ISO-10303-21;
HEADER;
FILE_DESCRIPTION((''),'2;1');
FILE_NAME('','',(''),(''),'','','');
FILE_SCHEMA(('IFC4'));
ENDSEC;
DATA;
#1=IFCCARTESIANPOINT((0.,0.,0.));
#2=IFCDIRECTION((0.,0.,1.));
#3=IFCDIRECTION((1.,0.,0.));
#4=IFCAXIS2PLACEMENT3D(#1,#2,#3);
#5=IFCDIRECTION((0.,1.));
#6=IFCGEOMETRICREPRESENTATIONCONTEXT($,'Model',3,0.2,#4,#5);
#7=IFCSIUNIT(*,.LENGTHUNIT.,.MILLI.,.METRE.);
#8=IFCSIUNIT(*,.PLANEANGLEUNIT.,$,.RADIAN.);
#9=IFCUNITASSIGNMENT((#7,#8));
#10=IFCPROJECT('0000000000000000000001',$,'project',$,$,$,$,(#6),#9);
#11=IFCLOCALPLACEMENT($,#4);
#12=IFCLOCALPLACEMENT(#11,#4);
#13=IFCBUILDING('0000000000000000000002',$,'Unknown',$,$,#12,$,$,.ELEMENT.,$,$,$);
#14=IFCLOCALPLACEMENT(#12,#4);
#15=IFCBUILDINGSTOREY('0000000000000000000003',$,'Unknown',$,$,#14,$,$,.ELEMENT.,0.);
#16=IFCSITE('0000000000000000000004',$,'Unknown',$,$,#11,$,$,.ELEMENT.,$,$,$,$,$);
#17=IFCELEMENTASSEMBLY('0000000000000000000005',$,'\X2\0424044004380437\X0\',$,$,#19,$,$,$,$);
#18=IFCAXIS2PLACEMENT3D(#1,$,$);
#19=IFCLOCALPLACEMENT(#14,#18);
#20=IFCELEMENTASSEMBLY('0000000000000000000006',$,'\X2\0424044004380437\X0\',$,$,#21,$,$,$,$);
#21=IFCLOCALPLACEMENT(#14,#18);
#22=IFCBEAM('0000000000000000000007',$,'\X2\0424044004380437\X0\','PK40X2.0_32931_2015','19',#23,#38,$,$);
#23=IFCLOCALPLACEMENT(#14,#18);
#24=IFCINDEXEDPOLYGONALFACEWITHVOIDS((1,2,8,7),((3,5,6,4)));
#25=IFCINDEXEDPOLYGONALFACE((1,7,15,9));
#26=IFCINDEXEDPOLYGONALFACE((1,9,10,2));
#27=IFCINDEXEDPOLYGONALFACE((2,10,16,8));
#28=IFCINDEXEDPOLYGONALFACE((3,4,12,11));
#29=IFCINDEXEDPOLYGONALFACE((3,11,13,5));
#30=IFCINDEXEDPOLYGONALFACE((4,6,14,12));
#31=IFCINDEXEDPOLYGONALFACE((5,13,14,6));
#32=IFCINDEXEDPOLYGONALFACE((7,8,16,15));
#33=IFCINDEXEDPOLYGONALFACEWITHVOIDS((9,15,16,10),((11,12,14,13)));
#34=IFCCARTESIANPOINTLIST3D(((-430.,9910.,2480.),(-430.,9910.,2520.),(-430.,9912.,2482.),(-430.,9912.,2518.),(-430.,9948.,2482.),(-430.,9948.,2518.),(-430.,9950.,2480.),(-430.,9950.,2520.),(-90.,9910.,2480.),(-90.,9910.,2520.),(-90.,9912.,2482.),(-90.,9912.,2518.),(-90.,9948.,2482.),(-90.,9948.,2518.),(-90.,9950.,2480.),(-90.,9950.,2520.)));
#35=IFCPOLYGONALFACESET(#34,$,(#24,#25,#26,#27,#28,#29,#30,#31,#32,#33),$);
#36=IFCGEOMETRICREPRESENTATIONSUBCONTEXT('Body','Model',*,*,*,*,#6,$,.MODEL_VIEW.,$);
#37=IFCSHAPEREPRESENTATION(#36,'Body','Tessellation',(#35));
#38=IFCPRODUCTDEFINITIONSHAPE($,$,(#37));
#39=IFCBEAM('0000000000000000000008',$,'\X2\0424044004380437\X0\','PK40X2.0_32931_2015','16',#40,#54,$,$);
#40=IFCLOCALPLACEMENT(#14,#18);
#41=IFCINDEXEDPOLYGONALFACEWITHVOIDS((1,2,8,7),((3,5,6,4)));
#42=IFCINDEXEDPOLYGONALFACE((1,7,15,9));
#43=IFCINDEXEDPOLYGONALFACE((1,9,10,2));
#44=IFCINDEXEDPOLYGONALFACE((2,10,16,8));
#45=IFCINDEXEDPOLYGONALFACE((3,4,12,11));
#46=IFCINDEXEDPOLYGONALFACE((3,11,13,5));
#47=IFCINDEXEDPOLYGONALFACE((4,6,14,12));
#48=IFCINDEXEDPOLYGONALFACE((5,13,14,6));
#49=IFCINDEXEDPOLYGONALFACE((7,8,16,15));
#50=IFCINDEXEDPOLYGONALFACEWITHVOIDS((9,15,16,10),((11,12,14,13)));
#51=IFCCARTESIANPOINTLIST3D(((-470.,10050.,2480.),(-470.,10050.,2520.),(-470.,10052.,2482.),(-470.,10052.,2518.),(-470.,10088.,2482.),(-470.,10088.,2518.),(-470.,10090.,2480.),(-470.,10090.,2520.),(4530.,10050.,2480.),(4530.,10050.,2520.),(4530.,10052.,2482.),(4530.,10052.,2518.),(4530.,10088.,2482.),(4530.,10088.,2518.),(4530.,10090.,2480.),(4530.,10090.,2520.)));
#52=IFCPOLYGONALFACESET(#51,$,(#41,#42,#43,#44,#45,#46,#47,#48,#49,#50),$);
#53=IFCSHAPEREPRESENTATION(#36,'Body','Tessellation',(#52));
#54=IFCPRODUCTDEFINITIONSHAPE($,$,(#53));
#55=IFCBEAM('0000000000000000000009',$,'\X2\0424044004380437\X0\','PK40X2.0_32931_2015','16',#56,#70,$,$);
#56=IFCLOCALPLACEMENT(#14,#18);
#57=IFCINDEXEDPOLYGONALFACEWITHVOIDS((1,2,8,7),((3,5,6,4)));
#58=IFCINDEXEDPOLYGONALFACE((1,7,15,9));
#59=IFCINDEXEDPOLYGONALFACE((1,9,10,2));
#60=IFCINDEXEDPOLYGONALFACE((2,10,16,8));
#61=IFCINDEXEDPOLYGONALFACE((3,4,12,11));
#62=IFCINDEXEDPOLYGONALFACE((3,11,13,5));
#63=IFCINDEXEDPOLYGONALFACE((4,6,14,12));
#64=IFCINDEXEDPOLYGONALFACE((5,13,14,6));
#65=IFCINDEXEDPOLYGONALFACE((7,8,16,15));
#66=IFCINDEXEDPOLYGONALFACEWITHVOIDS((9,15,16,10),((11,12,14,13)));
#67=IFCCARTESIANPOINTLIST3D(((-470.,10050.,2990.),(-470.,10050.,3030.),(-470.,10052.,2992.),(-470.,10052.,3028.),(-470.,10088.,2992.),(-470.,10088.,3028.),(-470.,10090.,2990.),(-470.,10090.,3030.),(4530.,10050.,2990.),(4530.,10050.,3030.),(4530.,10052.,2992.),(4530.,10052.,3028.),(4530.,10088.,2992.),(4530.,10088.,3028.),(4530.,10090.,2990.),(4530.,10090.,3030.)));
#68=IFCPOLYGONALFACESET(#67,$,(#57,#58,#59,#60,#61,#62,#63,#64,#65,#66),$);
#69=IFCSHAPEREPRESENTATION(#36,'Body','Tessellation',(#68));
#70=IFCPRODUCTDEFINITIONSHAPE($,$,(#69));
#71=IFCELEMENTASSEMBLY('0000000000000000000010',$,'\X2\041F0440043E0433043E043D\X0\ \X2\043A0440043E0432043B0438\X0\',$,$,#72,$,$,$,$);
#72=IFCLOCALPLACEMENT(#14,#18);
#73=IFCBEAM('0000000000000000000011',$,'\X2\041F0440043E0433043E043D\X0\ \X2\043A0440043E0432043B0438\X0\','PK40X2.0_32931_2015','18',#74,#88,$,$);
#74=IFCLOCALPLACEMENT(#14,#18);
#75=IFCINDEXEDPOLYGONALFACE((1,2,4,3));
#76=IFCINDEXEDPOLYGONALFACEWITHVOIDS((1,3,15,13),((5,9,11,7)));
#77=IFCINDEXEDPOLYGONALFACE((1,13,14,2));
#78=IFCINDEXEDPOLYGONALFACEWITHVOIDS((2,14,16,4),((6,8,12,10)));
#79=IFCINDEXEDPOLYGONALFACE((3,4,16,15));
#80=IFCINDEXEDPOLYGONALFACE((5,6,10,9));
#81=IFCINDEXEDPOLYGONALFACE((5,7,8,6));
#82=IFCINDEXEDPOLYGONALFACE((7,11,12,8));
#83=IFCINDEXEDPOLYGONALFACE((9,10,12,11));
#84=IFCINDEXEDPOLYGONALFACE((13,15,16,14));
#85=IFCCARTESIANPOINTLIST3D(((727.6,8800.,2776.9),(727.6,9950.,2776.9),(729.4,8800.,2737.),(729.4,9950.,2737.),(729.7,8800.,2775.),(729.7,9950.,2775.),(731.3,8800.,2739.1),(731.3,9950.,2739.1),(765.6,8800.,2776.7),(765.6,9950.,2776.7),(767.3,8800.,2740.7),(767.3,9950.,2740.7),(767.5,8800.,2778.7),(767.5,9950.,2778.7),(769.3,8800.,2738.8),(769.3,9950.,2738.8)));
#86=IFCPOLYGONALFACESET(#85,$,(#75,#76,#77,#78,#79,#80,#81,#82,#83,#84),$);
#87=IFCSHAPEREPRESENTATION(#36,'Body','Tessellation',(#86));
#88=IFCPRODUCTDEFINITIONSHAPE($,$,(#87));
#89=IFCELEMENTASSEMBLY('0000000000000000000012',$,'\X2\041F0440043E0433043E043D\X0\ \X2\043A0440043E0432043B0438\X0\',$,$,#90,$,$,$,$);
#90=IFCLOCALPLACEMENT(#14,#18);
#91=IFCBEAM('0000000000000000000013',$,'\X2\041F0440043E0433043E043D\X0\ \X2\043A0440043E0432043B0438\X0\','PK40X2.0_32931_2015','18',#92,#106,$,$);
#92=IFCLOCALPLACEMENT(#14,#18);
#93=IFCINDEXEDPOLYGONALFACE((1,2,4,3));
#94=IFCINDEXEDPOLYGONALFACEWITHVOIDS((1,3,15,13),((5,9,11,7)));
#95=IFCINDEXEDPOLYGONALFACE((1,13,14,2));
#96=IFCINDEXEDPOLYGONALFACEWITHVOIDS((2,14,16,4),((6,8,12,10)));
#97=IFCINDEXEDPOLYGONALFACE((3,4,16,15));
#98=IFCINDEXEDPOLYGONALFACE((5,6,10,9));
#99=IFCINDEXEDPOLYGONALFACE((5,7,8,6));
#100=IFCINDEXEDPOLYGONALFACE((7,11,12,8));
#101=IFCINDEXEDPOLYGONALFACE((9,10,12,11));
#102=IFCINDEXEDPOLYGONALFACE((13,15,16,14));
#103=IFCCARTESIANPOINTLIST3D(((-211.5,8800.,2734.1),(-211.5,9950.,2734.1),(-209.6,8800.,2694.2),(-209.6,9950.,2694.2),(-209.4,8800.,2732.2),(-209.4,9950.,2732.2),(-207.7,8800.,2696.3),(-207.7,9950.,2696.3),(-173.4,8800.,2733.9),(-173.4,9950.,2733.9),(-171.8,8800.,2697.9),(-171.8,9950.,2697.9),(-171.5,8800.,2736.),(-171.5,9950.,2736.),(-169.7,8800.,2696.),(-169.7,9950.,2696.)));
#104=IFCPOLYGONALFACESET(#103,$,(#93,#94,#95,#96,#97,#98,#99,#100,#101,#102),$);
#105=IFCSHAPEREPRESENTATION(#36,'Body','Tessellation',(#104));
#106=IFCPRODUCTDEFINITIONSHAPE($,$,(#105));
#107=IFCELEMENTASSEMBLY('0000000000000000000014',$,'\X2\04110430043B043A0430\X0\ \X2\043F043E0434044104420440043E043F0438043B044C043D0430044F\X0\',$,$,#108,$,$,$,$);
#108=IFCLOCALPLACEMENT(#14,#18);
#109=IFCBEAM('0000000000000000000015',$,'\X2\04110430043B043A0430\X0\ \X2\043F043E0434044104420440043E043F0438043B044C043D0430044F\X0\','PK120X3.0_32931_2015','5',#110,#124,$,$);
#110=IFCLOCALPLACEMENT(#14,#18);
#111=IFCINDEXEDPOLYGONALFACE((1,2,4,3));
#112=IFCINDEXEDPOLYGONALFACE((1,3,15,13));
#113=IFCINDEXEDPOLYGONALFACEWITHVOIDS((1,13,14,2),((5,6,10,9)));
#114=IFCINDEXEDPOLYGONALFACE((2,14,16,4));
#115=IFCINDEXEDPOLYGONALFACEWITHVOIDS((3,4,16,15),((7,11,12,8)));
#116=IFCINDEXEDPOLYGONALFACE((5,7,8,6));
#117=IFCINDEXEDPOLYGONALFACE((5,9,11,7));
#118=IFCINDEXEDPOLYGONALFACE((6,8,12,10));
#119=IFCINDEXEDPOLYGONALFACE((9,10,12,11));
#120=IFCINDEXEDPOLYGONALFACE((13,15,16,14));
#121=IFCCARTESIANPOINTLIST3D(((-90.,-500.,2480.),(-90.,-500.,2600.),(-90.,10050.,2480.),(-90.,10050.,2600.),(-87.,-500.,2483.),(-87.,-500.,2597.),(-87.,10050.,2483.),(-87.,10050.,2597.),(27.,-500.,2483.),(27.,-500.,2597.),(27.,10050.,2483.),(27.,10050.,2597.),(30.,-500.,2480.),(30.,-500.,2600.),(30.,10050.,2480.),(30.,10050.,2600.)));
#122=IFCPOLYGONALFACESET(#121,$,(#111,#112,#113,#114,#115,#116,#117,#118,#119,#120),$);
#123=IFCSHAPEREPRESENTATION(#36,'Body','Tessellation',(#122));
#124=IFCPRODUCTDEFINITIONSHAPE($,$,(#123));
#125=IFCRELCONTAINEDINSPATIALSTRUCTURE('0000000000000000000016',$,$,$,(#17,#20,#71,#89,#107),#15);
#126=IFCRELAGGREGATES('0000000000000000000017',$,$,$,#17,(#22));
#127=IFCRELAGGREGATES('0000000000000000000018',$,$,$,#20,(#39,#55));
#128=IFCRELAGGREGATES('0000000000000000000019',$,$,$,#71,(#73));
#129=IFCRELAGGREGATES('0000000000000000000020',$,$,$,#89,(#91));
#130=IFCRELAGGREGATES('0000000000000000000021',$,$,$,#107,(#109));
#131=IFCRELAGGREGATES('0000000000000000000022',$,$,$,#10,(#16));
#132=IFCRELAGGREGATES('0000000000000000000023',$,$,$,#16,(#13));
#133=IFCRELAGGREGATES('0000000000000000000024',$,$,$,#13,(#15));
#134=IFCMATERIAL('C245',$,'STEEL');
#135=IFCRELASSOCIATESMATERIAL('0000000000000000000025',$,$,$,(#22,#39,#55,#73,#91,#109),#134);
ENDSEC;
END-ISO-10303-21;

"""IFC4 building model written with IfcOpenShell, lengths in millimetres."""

from ifc_helpers import new_model, si_unit, direction, frame, origin_with_axes, place, context, subcontext, project, spatial, line, indexed_curve, outline, extrude, material, element, aggregate, save


model = new_model("IFC4")

# Units and contexts
model_context = context("Model", 3, precision=0.2, world=origin_with_axes(), true_north=direction((0.0, 1.0)))
body_context = subcontext(model_context, "Body", "Model", "MODEL_VIEW")
ifc_project = project(units=[si_unit("LENGTHUNIT", "METRE", prefix="MILLI"), si_unit("PLANEANGLEUNIT", "RADIAN")], contexts=[model_context])

# Site, building, storey
site_placement = place(None, origin_with_axes())
site = spatial("IfcSite", under=ifc_project, at=site_placement, Name="Unknown", CompositionType="ELEMENT")
building_placement = place(site_placement, origin_with_axes())
building = spatial("IfcBuilding", under=site, at=building_placement, Name="Unknown", CompositionType="ELEMENT")
storey_placement = place(building_placement, origin_with_axes())
storey = spatial("IfcBuildingStorey", under=building, at=storey_placement, Name="Unknown", CompositionType="ELEMENT", Elevation=0.0)

# Element assemblies
assembly_1_placement = place(storey_placement, frame((-450.0, -500.0, 3010.0), z_axis=(1.0, 0.0, 0.0), x_axis=(0.0, 1.0, 0.0)))
assembly_1 = element("IfcElementAssembly", 1, at=assembly_1_placement, inside=storey, Name="Фриз")
ifc_material = material(Name="C245", Category="STEEL")
assembly_2_placement = place(storey_placement, frame((-470.0, 10070.0, 3010.0), z_axis=(0.0, -1.0, 0.0), x_axis=(1.0, 0.0, 0.0)))
assembly_2 = element("IfcElementAssembly", 2, at=assembly_2_placement, inside=storey, Name="Фриз")

# Beams
beam_1_placement = place(assembly_1_placement, frame((10430.0, -510.0, 20.0), z_axis=(-1.0, 0.0, 0.0), x_axis=(0.0, 0.0, 1.0)))
beam_1 = element("IfcBeam", 3, at=beam_1_placement, material=ifc_material, Name="Фриз", Description="PK40X2.0_32931_2015", ObjectType="19", context=body_context, shape_type="SolidModel", body=[
    extrude(outline(indexed_curve([(-20.0, -20.0), (20.0, -20.0), (20.0, 20.0), (-20.0, 20.0)], segments=[line(1, 2, 3, 4, 1)]), holes=[indexed_curve([(-18.0, -18.0), (-18.0, 18.0), (18.0, 18.0), (18.0, -18.0)], segments=[line(1, 2, 3, 4, 1)])]), frame((0.0, 0.0, 0.0), z_axis=(-1.0, 0.0, 0.0), x_axis=(0.0, 0.0, 1.0)), (0.0, 0.0, -1.0), 340.0),
])
aggregate(assembly_1, [beam_1])
beam_2_placement = place(assembly_2_placement, frame((0.0, -510.0, 0.0), z_axis=(0.0, 0.0, 1.0), x_axis=(1.0, 0.0, 0.0)))
beam_2 = element("IfcBeam", 4, at=beam_2_placement, material=ifc_material, Name="Фриз", Description="PK40X2.0_32931_2015", ObjectType="16", context=body_context, shape_type="SolidModel", body=[
    extrude(outline(indexed_curve([(-20.0, -20.0), (20.0, -20.0), (20.0, 20.0), (-20.0, 20.0)], segments=[line(1, 2, 3, 4, 1)]), holes=[indexed_curve([(-18.0, -18.0), (-18.0, 18.0), (18.0, 18.0), (18.0, -18.0)], segments=[line(1, 2, 3, 4, 1)])]), frame((0.0, 0.0, 0.0), z_axis=(-1.0, 0.0, 0.0), x_axis=(0.0, 0.0, 1.0)), (0.0, 0.0, -1.0), 5000.0),
])
beam_3_placement = place(assembly_2_placement, origin_with_axes())
beam_3 = element("IfcBeam", 5, at=beam_3_placement, material=ifc_material, Name="Фриз", Description="PK40X2.0_32931_2015", ObjectType="16", context=body_context, shape_type="SolidModel", body=[
    extrude(outline(indexed_curve([(-20.0, -20.0), (20.0, -20.0), (20.0, 20.0), (-20.0, 20.0)], segments=[line(1, 2, 3, 4, 1)]), holes=[indexed_curve([(-18.0, -18.0), (-18.0, 18.0), (18.0, 18.0), (18.0, -18.0)], segments=[line(1, 2, 3, 4, 1)])]), frame((0.0, 0.0, 0.0), z_axis=(-1.0, 0.0, 0.0), x_axis=(0.0, 0.0, 1.0)), (0.0, 0.0, -1.0), 5000.0),
])
aggregate(assembly_2, [beam_2, beam_3])

# Element assemblies, beams
assembly_3_placement = place(storey_placement, frame((748.5, 9950.0, 2757.9), z_axis=(-0.998964, 0.0, -0.045508), x_axis=(0.0, -1.0, 0.0)))
assembly_3 = element("IfcElementAssembly", 6, at=assembly_3_placement, inside=storey, Name="Прогон кровли")
beam_4_placement = place(assembly_3_placement, origin_with_axes())
beam_4 = element("IfcBeam", 7, at=beam_4_placement, material=ifc_material, Name="Прогон кровли", Description="PK40X2.0_32931_2015", ObjectType="18", context=body_context, shape_type="SolidModel", body=[
    extrude(outline(indexed_curve([(-20.0, -20.0), (20.0, -20.0), (20.0, 20.0), (-20.0, 20.0)], segments=[line(1, 2, 3, 4, 1)]), holes=[indexed_curve([(-18.0, -18.0), (-18.0, 18.0), (18.0, 18.0), (18.0, -18.0)], segments=[line(1, 2, 3, 4, 1)])]), frame((0.0, 0.0, 0.0), z_axis=(-1.0, 0.0, 0.0), x_axis=(0.0, 0.0, 1.0)), (0.0, 0.0, -1.0), 1150.0),
])
aggregate(assembly_3, [beam_4])
assembly_4_placement = place(storey_placement, frame((-190.6, 9950.0, 2715.1), z_axis=(-0.998964, 0.0, -0.045508), x_axis=(0.0, -1.0, 0.0)))
assembly_4 = element("IfcElementAssembly", 8, at=assembly_4_placement, inside=storey, Name="Прогон кровли")
beam_5_placement = place(assembly_4_placement, origin_with_axes())
beam_5 = element("IfcBeam", 9, at=beam_5_placement, material=ifc_material, Name="Прогон кровли", Description="PK40X2.0_32931_2015", ObjectType="18", context=body_context, shape_type="SolidModel", body=[
    extrude(outline(indexed_curve([(-20.0, -20.0), (20.0, -20.0), (20.0, 20.0), (-20.0, 20.0)], segments=[line(1, 2, 3, 4, 1)]), holes=[indexed_curve([(-18.0, -18.0), (-18.0, 18.0), (18.0, 18.0), (18.0, -18.0)], segments=[line(1, 2, 3, 4, 1)])]), frame((0.0, 0.0, 0.0), z_axis=(-1.0, 0.0, 0.0), x_axis=(0.0, 0.0, 1.0)), (0.0, 0.0, -1.0), 1150.0),
])
aggregate(assembly_4, [beam_5])
assembly_5_placement = place(storey_placement, frame((-30.0, 10050.0, 2540.0), z_axis=(-1.0, 0.0, 0.0), x_axis=(0.0, -1.0, 0.0)))
assembly_5 = element("IfcElementAssembly", 10, at=assembly_5_placement, inside=storey, Name="Балка подстропильная")
beam_6_placement = place(assembly_5_placement, origin_with_axes())
beam_6 = element("IfcBeam", 11, at=beam_6_placement, material=ifc_material, Name="Балка подстропильная", Description="PK120X3.0_32931_2015", ObjectType="5", context=body_context, shape_type="SolidModel", body=[
    extrude(outline(indexed_curve([(-60.0, -60.0), (60.0, -60.0), (60.0, 60.0), (-60.0, 60.0)], segments=[line(1, 2, 3, 4, 1)]), holes=[indexed_curve([(-57.0, -57.0), (-57.0, 57.0), (57.0, 57.0), (57.0, -57.0)], segments=[line(1, 2, 3, 4, 1)])]), frame((0.0, 0.0, 0.0), z_axis=(-1.0, 0.0, 0.0), x_axis=(0.0, 0.0, 1.0)), (0.0, 0.0, -1.0), 10550.0),
])
aggregate(assembly_5, [beam_6])

save(model, "model.ifc")
